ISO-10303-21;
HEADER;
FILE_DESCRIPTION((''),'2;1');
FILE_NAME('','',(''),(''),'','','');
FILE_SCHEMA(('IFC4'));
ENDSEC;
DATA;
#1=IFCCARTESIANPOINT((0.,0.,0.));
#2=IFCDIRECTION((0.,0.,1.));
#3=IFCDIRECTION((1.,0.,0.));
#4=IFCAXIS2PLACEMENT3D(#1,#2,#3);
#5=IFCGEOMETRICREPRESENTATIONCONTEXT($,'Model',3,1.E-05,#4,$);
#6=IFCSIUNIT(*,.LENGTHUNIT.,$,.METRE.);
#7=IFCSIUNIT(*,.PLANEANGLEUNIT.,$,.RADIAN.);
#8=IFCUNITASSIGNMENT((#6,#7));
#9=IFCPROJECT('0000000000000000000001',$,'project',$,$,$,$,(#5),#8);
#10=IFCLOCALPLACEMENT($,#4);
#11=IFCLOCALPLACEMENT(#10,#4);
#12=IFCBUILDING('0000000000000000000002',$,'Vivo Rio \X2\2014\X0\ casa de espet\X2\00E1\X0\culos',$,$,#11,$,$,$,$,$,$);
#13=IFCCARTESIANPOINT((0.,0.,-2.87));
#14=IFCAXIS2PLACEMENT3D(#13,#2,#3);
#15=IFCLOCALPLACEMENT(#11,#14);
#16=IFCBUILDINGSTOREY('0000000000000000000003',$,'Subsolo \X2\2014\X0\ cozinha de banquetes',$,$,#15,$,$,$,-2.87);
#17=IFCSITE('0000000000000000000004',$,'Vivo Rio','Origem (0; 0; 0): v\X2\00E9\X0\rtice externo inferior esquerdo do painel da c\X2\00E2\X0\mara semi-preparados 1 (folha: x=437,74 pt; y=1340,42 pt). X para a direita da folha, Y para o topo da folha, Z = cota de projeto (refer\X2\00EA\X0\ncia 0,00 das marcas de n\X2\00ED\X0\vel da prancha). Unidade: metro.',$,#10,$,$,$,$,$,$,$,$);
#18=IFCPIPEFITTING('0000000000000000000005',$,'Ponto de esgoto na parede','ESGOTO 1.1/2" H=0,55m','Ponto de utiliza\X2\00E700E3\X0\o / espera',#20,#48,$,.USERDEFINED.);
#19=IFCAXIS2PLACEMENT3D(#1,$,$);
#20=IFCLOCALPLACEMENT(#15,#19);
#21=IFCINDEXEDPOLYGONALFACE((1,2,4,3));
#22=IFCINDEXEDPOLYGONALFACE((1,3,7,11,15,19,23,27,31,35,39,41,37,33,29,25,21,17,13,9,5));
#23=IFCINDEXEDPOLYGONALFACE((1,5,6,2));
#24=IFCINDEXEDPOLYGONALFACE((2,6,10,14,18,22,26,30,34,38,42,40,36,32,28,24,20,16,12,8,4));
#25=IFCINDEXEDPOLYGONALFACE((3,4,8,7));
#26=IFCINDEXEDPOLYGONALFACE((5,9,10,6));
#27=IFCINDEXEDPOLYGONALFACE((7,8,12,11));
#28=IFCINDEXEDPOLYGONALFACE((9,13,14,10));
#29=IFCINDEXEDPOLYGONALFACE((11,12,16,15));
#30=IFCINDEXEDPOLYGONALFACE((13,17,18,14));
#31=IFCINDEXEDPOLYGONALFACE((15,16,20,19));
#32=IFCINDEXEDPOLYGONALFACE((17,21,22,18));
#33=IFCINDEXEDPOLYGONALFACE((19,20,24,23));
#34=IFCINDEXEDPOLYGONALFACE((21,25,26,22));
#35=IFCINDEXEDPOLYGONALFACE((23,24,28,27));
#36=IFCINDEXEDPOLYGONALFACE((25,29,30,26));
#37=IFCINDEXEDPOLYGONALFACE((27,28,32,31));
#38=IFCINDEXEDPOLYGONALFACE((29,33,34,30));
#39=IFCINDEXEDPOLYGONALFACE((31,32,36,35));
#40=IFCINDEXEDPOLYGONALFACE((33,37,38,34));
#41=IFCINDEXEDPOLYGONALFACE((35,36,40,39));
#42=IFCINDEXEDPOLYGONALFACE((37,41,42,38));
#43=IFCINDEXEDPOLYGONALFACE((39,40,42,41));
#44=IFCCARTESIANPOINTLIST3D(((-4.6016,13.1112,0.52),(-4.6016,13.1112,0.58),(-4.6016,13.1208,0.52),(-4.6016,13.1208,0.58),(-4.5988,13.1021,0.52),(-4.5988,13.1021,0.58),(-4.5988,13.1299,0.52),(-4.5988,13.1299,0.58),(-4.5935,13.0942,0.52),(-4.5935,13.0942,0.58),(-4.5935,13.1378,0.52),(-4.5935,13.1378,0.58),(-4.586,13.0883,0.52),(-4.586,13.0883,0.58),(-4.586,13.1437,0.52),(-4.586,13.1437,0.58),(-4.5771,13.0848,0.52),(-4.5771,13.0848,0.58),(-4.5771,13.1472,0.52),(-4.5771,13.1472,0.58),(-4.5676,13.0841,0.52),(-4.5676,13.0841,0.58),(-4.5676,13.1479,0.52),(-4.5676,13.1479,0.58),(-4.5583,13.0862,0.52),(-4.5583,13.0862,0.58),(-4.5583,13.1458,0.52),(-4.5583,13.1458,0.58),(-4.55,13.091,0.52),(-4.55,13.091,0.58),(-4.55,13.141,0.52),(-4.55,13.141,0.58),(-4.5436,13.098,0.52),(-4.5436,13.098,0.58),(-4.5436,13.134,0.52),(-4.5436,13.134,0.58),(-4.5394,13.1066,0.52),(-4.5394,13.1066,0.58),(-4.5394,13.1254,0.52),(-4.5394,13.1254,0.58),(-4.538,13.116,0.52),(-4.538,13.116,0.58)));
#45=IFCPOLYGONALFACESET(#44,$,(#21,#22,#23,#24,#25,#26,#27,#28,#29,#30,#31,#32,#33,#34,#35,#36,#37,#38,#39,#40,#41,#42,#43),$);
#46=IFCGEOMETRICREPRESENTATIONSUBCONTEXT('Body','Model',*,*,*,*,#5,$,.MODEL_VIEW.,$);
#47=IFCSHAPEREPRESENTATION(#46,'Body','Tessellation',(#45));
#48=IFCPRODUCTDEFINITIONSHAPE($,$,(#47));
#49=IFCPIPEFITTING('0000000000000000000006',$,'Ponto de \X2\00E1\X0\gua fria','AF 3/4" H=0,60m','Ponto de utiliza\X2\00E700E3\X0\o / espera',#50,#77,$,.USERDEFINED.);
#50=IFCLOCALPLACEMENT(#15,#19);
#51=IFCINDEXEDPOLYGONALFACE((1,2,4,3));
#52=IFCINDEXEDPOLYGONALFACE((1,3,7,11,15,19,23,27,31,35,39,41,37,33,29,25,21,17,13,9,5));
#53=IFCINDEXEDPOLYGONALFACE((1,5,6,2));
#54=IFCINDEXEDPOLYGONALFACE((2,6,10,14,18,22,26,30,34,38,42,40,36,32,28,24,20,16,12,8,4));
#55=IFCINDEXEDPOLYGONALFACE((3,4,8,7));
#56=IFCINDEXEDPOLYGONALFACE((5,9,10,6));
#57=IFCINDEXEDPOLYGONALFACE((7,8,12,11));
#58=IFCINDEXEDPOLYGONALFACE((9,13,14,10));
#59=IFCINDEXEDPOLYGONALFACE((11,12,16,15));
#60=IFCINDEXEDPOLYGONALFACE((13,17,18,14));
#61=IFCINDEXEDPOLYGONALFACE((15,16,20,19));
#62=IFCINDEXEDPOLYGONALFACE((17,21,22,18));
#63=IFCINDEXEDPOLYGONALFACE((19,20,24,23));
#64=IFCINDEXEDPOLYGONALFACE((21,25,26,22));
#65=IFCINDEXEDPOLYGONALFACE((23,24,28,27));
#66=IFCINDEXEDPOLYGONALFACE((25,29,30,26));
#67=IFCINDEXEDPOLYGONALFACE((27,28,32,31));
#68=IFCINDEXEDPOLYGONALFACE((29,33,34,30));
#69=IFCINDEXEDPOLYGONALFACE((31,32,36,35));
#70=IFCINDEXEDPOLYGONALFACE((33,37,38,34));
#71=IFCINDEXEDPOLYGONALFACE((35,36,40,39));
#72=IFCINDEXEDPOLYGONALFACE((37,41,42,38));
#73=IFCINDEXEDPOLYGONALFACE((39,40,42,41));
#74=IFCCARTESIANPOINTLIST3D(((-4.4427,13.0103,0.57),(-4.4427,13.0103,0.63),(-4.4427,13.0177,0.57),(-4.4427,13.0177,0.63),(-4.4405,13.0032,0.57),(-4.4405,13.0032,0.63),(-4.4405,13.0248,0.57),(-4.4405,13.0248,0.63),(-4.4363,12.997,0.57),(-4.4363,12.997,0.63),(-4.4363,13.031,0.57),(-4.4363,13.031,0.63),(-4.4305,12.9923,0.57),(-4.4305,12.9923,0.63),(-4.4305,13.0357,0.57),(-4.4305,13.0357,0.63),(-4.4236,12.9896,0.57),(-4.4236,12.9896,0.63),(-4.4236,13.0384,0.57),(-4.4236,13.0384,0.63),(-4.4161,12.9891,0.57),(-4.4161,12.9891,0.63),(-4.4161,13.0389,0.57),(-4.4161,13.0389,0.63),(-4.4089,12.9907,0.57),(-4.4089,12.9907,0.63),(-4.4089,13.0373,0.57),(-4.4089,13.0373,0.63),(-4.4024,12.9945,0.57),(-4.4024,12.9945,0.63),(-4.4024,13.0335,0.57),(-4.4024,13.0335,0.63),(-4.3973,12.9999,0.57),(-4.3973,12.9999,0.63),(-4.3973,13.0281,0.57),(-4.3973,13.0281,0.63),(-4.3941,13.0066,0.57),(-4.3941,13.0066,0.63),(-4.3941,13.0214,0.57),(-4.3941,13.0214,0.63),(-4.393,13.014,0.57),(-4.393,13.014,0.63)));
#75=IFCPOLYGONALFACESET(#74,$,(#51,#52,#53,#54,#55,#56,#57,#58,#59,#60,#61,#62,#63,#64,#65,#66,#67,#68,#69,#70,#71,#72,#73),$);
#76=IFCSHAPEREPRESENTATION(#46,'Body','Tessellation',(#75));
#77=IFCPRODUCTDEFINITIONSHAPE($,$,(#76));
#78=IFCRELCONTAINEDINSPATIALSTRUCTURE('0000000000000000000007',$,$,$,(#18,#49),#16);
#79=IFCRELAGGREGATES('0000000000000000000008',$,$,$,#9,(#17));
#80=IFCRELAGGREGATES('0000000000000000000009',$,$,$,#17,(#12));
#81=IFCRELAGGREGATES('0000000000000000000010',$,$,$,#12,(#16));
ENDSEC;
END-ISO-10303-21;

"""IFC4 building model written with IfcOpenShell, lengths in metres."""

from ifc_helpers import new_model, si_unit, frame, origin_with_axes, origin_2d, place, context, subcontext, project, spatial, circle, extrude, element, save


model = new_model("IFC4")

# Units and contexts
model_context = context("Model", 3, precision=1e-05, world=origin_with_axes())
body_context = subcontext(model_context, "Body", "Model", "MODEL_VIEW")
ifc_project = project(units=[si_unit("LENGTHUNIT", "METRE"), si_unit("PLANEANGLEUNIT", "RADIAN")], contexts=[model_context])

# Site, building, storey
site_placement = place(None, origin_with_axes())
site = spatial("IfcSite", under=ifc_project, at=site_placement, Name="Vivo Rio", Description="Origem (0; 0; 0): vértice externo inferior esquerdo do painel da câmara semi-preparados 1 (folha: x=437,74 pt; y=1340,42 pt). X para a direita da folha, Y para o topo da folha, Z = cota de projeto (referência 0,00 das marcas de nível da prancha). Unidade: metro.")
building_placement = place(site_placement, origin_with_axes())
building = spatial("IfcBuilding", under=site, at=building_placement, Name="Vivo Rio — casa de espetáculos")
storey_placement = place(building_placement, frame((0.0, 0.0, -2.87), z_axis=(0.0, 0.0, 1.0), x_axis=(1.0, 0.0, 0.0)))
storey = spatial("IfcBuildingStorey", under=building, at=storey_placement, Name="Subsolo — cozinha de banquetes", Elevation=-2.87)

# Pipe fittings
pipe_fitting_1_placement = place(storey_placement, origin_with_axes())
element("IfcPipeFitting", 1, at=pipe_fitting_1_placement, inside=storey, Name="Ponto de esgoto na parede", Description="ESGOTO 1.1/2\" H=0,55m", ObjectType="Ponto de utilização / espera", PredefinedType="USERDEFINED", context=body_context, shape_type="SweptSolid", body=[
    extrude(circle(Radius=0.032, at=origin_2d()), frame((-4.57, 13.116, 0.52), z_axis=(0.0, 0.0, 1.0), x_axis=(1.0, 0.0, 0.0)), (0.0, 0.0, 1.0), 0.06),
])
pipe_fitting_2_placement = place(storey_placement, origin_with_axes())
element("IfcPipeFitting", 2, at=pipe_fitting_2_placement, inside=storey, Name="Ponto de água fria", Description="AF 3/4\" H=0,60m", ObjectType="Ponto de utilização / espera", PredefinedType="USERDEFINED", context=body_context, shape_type="SweptSolid", body=[
    extrude(circle(Radius=0.025, at=origin_2d()), frame((-4.418, 13.014, 0.57), z_axis=(0.0, 0.0, 1.0), x_axis=(1.0, 0.0, 0.0)), (0.0, 0.0, 1.0), 0.06),
])

save(model, "model.ifc")
